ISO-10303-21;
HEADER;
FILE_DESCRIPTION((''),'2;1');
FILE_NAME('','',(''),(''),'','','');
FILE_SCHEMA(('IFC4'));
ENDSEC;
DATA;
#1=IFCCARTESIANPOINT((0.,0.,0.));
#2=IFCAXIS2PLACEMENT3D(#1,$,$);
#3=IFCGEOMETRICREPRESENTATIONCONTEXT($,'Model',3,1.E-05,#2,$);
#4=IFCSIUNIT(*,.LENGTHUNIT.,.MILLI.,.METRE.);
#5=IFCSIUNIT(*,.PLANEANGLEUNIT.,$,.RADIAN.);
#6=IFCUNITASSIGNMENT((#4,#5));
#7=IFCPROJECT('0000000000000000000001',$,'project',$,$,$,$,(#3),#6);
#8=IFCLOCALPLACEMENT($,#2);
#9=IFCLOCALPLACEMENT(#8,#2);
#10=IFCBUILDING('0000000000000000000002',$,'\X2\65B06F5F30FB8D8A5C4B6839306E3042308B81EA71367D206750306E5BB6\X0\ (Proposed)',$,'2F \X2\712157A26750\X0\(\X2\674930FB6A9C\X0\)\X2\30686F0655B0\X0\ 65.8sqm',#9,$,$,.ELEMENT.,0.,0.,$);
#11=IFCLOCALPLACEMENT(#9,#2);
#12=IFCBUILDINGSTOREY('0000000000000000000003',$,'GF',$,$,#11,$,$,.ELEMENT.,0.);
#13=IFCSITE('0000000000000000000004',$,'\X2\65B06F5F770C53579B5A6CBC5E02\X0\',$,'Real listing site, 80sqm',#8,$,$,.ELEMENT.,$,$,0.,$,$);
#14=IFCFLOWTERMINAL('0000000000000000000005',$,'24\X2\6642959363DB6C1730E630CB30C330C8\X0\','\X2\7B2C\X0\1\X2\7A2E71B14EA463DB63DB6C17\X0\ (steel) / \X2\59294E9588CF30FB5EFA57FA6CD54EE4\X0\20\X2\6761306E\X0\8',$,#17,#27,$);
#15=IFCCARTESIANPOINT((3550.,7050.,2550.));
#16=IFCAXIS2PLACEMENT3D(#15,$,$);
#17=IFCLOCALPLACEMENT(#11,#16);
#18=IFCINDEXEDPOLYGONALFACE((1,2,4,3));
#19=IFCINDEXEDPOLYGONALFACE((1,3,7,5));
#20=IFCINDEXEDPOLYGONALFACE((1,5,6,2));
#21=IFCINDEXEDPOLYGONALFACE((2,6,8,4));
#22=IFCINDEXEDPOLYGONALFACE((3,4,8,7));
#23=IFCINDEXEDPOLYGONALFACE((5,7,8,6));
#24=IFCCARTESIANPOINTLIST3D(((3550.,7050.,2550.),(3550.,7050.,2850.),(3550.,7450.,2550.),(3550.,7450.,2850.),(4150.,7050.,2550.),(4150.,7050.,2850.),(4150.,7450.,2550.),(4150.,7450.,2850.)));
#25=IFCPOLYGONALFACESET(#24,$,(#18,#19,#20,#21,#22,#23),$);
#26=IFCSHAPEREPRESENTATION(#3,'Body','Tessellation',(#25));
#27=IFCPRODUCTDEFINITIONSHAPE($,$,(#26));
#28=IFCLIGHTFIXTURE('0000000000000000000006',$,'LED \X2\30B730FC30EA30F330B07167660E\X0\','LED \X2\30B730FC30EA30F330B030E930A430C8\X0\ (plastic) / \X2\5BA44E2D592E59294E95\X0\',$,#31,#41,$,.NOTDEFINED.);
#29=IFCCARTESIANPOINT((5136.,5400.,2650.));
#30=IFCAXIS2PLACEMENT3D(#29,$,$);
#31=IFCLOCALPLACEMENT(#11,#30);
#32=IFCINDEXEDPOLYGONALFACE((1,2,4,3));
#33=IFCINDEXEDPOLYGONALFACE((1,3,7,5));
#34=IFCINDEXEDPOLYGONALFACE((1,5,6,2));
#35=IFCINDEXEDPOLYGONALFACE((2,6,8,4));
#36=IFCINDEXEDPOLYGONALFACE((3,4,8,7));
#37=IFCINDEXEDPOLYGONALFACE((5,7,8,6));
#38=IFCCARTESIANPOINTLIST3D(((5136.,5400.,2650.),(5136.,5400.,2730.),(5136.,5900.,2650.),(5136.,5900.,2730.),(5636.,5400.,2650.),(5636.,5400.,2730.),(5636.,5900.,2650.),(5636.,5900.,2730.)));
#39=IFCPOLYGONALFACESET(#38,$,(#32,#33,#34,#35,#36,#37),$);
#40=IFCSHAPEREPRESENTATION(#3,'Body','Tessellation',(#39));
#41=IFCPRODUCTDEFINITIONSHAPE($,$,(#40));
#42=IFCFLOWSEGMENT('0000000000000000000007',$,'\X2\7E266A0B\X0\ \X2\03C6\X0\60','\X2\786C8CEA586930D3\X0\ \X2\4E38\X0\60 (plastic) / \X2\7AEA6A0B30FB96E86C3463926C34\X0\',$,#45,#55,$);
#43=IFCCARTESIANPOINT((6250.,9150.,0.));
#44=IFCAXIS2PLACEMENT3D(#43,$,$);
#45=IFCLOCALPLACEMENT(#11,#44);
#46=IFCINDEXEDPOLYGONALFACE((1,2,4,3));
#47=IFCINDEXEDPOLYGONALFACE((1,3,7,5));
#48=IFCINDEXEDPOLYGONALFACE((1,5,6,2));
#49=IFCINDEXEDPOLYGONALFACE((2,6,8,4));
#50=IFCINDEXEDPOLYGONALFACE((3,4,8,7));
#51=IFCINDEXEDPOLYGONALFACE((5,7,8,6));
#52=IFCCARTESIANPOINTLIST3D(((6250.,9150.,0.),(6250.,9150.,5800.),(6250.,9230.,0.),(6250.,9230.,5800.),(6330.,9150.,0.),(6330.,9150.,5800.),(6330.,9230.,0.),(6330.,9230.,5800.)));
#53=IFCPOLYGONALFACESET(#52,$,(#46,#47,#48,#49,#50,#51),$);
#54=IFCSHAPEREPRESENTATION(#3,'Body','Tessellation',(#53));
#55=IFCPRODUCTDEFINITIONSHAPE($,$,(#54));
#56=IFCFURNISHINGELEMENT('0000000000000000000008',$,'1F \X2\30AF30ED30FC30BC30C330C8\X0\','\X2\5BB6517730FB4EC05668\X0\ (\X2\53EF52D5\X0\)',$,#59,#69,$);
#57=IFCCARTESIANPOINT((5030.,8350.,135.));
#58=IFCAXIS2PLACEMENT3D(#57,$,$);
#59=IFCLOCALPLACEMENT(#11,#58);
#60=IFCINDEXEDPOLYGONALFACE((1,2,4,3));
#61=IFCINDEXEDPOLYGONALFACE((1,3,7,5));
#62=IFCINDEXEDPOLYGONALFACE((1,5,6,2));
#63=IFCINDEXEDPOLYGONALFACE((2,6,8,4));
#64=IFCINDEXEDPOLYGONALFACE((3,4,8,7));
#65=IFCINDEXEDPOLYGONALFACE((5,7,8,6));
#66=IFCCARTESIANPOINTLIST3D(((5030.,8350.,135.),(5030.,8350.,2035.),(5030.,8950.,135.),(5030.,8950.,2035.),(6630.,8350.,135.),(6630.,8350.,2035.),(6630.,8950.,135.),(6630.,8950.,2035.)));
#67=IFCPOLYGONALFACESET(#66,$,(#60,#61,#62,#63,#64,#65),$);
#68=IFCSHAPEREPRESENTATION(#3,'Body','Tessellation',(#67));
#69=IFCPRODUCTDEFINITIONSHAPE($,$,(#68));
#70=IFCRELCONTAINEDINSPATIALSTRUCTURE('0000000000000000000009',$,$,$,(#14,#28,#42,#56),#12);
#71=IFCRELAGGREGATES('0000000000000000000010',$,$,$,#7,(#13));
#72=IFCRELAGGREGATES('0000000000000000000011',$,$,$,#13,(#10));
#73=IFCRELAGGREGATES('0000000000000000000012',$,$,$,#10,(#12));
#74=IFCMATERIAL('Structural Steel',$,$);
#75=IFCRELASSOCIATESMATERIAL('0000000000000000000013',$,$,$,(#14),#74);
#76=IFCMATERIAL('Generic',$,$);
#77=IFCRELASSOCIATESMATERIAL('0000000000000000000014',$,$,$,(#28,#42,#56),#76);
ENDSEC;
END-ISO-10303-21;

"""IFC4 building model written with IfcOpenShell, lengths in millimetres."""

from ifc_helpers import new_model, si_unit, frame, frame_2d, origin, place, context, project, spatial, rectangle, extrude, material, element, save


model = new_model("IFC4")

# Units and contexts
model_context = context("Model", 3, precision=1e-05, world=origin())
ifc_project = project(units=[si_unit("LENGTHUNIT", "METRE", prefix="MILLI"), si_unit("PLANEANGLEUNIT", "RADIAN")], contexts=[model_context])

# Site, building, storey
site_placement = place(None, origin())
site = spatial("IfcSite", under=ifc_project, at=site_placement, Name="新潟県南魚沼市", ObjectType="Real listing site, 80sqm", CompositionType="ELEMENT", RefElevation=0.0)
building_placement = place(site_placement, origin())
building = spatial("IfcBuilding", under=site, at=building_placement, Name="新潟・越屋根のある自然素材の家 (Proposed)", ObjectType="2F 無垢材(杉・檜)と漆喰 65.8sqm", CompositionType="ELEMENT", ElevationOfRefHeight=0.0, ElevationOfTerrain=0.0)
storey_placement = place(building_placement, origin())
storey = spatial("IfcBuildingStorey", under=building, at=storey_placement, Name="GF", CompositionType="ELEMENT", Elevation=0.0)

# Shared definitions
ifc_material_1 = material(Name="Generic")

# Flow terminal
ifc_material_2 = material(Name="Structural Steel")
flow_terminal_placement = place(storey_placement, frame((3550.0, 7050.0, 2550.0)))
element("IfcFlowTerminal", 1, at=flow_terminal_placement, inside=storey, material=ifc_material_2, Name="24時間換気ユニット", Description="第1種熱交換換気 (steel) / 天井裏・建基法令20条の8", context=model_context, shape_type="SweptSolid", body=[
    extrude(rectangle(XDim=600.0, YDim=400.0, at=frame_2d((300.0, 200.0))), frame((3550.0, 7050.0, 2550.0)), (0.0, 0.0, 1.0), 300.0),
])

# Light fixture
light_fixture_placement = place(storey_placement, frame((5136.0, 5400.0, 2650.0)))
element("IfcLightFixture", 2, at=light_fixture_placement, inside=storey, material=ifc_material_1, Name="LED シーリング照明", Description="LED シーリングライト (plastic) / 室中央天井", PredefinedType="NOTDEFINED", context=model_context, shape_type="SweptSolid", body=[
    extrude(rectangle(XDim=500.0, YDim=500.0, at=frame_2d((250.0, 250.0))), frame((5136.0, 5400.0, 2650.0)), (0.0, 0.0, 1.0), 80.0),
])

# Flow segment
flow_segment_placement = place(storey_placement, frame((6250.0, 9150.0, 0.0)))
element("IfcFlowSegment", 3, at=flow_segment_placement, inside=storey, material=ifc_material_1, Name="縦樋 φ60", Description="硬質塩ビ 丸60 (plastic) / 竪樋・雨水排水", context=model_context, shape_type="SweptSolid", body=[
    extrude(rectangle(XDim=80.0, YDim=80.0, at=frame_2d((40.0, 40.0))), frame((6250.0, 9150.0, 0.0)), (0.0, 0.0, 1.0), 5800.0),
])

# Furnishing element
furnishing_placement = place(storey_placement, frame((5030.0, 8350.0, 135.0)))
element("IfcFurnishingElement", 4, at=furnishing_placement, inside=storey, material=ifc_material_1, Name="1F クローゼット", Description="家具・什器 (可動)", context=model_context, shape_type="SweptSolid", body=[
    extrude(rectangle(XDim=1600.0, YDim=600.0, at=frame_2d((800.0, 300.0))), frame((5030.0, 8350.0, 135.0)), (0.0, 0.0, 1.0), 1900.0),
])

save(model, "model.ifc")
